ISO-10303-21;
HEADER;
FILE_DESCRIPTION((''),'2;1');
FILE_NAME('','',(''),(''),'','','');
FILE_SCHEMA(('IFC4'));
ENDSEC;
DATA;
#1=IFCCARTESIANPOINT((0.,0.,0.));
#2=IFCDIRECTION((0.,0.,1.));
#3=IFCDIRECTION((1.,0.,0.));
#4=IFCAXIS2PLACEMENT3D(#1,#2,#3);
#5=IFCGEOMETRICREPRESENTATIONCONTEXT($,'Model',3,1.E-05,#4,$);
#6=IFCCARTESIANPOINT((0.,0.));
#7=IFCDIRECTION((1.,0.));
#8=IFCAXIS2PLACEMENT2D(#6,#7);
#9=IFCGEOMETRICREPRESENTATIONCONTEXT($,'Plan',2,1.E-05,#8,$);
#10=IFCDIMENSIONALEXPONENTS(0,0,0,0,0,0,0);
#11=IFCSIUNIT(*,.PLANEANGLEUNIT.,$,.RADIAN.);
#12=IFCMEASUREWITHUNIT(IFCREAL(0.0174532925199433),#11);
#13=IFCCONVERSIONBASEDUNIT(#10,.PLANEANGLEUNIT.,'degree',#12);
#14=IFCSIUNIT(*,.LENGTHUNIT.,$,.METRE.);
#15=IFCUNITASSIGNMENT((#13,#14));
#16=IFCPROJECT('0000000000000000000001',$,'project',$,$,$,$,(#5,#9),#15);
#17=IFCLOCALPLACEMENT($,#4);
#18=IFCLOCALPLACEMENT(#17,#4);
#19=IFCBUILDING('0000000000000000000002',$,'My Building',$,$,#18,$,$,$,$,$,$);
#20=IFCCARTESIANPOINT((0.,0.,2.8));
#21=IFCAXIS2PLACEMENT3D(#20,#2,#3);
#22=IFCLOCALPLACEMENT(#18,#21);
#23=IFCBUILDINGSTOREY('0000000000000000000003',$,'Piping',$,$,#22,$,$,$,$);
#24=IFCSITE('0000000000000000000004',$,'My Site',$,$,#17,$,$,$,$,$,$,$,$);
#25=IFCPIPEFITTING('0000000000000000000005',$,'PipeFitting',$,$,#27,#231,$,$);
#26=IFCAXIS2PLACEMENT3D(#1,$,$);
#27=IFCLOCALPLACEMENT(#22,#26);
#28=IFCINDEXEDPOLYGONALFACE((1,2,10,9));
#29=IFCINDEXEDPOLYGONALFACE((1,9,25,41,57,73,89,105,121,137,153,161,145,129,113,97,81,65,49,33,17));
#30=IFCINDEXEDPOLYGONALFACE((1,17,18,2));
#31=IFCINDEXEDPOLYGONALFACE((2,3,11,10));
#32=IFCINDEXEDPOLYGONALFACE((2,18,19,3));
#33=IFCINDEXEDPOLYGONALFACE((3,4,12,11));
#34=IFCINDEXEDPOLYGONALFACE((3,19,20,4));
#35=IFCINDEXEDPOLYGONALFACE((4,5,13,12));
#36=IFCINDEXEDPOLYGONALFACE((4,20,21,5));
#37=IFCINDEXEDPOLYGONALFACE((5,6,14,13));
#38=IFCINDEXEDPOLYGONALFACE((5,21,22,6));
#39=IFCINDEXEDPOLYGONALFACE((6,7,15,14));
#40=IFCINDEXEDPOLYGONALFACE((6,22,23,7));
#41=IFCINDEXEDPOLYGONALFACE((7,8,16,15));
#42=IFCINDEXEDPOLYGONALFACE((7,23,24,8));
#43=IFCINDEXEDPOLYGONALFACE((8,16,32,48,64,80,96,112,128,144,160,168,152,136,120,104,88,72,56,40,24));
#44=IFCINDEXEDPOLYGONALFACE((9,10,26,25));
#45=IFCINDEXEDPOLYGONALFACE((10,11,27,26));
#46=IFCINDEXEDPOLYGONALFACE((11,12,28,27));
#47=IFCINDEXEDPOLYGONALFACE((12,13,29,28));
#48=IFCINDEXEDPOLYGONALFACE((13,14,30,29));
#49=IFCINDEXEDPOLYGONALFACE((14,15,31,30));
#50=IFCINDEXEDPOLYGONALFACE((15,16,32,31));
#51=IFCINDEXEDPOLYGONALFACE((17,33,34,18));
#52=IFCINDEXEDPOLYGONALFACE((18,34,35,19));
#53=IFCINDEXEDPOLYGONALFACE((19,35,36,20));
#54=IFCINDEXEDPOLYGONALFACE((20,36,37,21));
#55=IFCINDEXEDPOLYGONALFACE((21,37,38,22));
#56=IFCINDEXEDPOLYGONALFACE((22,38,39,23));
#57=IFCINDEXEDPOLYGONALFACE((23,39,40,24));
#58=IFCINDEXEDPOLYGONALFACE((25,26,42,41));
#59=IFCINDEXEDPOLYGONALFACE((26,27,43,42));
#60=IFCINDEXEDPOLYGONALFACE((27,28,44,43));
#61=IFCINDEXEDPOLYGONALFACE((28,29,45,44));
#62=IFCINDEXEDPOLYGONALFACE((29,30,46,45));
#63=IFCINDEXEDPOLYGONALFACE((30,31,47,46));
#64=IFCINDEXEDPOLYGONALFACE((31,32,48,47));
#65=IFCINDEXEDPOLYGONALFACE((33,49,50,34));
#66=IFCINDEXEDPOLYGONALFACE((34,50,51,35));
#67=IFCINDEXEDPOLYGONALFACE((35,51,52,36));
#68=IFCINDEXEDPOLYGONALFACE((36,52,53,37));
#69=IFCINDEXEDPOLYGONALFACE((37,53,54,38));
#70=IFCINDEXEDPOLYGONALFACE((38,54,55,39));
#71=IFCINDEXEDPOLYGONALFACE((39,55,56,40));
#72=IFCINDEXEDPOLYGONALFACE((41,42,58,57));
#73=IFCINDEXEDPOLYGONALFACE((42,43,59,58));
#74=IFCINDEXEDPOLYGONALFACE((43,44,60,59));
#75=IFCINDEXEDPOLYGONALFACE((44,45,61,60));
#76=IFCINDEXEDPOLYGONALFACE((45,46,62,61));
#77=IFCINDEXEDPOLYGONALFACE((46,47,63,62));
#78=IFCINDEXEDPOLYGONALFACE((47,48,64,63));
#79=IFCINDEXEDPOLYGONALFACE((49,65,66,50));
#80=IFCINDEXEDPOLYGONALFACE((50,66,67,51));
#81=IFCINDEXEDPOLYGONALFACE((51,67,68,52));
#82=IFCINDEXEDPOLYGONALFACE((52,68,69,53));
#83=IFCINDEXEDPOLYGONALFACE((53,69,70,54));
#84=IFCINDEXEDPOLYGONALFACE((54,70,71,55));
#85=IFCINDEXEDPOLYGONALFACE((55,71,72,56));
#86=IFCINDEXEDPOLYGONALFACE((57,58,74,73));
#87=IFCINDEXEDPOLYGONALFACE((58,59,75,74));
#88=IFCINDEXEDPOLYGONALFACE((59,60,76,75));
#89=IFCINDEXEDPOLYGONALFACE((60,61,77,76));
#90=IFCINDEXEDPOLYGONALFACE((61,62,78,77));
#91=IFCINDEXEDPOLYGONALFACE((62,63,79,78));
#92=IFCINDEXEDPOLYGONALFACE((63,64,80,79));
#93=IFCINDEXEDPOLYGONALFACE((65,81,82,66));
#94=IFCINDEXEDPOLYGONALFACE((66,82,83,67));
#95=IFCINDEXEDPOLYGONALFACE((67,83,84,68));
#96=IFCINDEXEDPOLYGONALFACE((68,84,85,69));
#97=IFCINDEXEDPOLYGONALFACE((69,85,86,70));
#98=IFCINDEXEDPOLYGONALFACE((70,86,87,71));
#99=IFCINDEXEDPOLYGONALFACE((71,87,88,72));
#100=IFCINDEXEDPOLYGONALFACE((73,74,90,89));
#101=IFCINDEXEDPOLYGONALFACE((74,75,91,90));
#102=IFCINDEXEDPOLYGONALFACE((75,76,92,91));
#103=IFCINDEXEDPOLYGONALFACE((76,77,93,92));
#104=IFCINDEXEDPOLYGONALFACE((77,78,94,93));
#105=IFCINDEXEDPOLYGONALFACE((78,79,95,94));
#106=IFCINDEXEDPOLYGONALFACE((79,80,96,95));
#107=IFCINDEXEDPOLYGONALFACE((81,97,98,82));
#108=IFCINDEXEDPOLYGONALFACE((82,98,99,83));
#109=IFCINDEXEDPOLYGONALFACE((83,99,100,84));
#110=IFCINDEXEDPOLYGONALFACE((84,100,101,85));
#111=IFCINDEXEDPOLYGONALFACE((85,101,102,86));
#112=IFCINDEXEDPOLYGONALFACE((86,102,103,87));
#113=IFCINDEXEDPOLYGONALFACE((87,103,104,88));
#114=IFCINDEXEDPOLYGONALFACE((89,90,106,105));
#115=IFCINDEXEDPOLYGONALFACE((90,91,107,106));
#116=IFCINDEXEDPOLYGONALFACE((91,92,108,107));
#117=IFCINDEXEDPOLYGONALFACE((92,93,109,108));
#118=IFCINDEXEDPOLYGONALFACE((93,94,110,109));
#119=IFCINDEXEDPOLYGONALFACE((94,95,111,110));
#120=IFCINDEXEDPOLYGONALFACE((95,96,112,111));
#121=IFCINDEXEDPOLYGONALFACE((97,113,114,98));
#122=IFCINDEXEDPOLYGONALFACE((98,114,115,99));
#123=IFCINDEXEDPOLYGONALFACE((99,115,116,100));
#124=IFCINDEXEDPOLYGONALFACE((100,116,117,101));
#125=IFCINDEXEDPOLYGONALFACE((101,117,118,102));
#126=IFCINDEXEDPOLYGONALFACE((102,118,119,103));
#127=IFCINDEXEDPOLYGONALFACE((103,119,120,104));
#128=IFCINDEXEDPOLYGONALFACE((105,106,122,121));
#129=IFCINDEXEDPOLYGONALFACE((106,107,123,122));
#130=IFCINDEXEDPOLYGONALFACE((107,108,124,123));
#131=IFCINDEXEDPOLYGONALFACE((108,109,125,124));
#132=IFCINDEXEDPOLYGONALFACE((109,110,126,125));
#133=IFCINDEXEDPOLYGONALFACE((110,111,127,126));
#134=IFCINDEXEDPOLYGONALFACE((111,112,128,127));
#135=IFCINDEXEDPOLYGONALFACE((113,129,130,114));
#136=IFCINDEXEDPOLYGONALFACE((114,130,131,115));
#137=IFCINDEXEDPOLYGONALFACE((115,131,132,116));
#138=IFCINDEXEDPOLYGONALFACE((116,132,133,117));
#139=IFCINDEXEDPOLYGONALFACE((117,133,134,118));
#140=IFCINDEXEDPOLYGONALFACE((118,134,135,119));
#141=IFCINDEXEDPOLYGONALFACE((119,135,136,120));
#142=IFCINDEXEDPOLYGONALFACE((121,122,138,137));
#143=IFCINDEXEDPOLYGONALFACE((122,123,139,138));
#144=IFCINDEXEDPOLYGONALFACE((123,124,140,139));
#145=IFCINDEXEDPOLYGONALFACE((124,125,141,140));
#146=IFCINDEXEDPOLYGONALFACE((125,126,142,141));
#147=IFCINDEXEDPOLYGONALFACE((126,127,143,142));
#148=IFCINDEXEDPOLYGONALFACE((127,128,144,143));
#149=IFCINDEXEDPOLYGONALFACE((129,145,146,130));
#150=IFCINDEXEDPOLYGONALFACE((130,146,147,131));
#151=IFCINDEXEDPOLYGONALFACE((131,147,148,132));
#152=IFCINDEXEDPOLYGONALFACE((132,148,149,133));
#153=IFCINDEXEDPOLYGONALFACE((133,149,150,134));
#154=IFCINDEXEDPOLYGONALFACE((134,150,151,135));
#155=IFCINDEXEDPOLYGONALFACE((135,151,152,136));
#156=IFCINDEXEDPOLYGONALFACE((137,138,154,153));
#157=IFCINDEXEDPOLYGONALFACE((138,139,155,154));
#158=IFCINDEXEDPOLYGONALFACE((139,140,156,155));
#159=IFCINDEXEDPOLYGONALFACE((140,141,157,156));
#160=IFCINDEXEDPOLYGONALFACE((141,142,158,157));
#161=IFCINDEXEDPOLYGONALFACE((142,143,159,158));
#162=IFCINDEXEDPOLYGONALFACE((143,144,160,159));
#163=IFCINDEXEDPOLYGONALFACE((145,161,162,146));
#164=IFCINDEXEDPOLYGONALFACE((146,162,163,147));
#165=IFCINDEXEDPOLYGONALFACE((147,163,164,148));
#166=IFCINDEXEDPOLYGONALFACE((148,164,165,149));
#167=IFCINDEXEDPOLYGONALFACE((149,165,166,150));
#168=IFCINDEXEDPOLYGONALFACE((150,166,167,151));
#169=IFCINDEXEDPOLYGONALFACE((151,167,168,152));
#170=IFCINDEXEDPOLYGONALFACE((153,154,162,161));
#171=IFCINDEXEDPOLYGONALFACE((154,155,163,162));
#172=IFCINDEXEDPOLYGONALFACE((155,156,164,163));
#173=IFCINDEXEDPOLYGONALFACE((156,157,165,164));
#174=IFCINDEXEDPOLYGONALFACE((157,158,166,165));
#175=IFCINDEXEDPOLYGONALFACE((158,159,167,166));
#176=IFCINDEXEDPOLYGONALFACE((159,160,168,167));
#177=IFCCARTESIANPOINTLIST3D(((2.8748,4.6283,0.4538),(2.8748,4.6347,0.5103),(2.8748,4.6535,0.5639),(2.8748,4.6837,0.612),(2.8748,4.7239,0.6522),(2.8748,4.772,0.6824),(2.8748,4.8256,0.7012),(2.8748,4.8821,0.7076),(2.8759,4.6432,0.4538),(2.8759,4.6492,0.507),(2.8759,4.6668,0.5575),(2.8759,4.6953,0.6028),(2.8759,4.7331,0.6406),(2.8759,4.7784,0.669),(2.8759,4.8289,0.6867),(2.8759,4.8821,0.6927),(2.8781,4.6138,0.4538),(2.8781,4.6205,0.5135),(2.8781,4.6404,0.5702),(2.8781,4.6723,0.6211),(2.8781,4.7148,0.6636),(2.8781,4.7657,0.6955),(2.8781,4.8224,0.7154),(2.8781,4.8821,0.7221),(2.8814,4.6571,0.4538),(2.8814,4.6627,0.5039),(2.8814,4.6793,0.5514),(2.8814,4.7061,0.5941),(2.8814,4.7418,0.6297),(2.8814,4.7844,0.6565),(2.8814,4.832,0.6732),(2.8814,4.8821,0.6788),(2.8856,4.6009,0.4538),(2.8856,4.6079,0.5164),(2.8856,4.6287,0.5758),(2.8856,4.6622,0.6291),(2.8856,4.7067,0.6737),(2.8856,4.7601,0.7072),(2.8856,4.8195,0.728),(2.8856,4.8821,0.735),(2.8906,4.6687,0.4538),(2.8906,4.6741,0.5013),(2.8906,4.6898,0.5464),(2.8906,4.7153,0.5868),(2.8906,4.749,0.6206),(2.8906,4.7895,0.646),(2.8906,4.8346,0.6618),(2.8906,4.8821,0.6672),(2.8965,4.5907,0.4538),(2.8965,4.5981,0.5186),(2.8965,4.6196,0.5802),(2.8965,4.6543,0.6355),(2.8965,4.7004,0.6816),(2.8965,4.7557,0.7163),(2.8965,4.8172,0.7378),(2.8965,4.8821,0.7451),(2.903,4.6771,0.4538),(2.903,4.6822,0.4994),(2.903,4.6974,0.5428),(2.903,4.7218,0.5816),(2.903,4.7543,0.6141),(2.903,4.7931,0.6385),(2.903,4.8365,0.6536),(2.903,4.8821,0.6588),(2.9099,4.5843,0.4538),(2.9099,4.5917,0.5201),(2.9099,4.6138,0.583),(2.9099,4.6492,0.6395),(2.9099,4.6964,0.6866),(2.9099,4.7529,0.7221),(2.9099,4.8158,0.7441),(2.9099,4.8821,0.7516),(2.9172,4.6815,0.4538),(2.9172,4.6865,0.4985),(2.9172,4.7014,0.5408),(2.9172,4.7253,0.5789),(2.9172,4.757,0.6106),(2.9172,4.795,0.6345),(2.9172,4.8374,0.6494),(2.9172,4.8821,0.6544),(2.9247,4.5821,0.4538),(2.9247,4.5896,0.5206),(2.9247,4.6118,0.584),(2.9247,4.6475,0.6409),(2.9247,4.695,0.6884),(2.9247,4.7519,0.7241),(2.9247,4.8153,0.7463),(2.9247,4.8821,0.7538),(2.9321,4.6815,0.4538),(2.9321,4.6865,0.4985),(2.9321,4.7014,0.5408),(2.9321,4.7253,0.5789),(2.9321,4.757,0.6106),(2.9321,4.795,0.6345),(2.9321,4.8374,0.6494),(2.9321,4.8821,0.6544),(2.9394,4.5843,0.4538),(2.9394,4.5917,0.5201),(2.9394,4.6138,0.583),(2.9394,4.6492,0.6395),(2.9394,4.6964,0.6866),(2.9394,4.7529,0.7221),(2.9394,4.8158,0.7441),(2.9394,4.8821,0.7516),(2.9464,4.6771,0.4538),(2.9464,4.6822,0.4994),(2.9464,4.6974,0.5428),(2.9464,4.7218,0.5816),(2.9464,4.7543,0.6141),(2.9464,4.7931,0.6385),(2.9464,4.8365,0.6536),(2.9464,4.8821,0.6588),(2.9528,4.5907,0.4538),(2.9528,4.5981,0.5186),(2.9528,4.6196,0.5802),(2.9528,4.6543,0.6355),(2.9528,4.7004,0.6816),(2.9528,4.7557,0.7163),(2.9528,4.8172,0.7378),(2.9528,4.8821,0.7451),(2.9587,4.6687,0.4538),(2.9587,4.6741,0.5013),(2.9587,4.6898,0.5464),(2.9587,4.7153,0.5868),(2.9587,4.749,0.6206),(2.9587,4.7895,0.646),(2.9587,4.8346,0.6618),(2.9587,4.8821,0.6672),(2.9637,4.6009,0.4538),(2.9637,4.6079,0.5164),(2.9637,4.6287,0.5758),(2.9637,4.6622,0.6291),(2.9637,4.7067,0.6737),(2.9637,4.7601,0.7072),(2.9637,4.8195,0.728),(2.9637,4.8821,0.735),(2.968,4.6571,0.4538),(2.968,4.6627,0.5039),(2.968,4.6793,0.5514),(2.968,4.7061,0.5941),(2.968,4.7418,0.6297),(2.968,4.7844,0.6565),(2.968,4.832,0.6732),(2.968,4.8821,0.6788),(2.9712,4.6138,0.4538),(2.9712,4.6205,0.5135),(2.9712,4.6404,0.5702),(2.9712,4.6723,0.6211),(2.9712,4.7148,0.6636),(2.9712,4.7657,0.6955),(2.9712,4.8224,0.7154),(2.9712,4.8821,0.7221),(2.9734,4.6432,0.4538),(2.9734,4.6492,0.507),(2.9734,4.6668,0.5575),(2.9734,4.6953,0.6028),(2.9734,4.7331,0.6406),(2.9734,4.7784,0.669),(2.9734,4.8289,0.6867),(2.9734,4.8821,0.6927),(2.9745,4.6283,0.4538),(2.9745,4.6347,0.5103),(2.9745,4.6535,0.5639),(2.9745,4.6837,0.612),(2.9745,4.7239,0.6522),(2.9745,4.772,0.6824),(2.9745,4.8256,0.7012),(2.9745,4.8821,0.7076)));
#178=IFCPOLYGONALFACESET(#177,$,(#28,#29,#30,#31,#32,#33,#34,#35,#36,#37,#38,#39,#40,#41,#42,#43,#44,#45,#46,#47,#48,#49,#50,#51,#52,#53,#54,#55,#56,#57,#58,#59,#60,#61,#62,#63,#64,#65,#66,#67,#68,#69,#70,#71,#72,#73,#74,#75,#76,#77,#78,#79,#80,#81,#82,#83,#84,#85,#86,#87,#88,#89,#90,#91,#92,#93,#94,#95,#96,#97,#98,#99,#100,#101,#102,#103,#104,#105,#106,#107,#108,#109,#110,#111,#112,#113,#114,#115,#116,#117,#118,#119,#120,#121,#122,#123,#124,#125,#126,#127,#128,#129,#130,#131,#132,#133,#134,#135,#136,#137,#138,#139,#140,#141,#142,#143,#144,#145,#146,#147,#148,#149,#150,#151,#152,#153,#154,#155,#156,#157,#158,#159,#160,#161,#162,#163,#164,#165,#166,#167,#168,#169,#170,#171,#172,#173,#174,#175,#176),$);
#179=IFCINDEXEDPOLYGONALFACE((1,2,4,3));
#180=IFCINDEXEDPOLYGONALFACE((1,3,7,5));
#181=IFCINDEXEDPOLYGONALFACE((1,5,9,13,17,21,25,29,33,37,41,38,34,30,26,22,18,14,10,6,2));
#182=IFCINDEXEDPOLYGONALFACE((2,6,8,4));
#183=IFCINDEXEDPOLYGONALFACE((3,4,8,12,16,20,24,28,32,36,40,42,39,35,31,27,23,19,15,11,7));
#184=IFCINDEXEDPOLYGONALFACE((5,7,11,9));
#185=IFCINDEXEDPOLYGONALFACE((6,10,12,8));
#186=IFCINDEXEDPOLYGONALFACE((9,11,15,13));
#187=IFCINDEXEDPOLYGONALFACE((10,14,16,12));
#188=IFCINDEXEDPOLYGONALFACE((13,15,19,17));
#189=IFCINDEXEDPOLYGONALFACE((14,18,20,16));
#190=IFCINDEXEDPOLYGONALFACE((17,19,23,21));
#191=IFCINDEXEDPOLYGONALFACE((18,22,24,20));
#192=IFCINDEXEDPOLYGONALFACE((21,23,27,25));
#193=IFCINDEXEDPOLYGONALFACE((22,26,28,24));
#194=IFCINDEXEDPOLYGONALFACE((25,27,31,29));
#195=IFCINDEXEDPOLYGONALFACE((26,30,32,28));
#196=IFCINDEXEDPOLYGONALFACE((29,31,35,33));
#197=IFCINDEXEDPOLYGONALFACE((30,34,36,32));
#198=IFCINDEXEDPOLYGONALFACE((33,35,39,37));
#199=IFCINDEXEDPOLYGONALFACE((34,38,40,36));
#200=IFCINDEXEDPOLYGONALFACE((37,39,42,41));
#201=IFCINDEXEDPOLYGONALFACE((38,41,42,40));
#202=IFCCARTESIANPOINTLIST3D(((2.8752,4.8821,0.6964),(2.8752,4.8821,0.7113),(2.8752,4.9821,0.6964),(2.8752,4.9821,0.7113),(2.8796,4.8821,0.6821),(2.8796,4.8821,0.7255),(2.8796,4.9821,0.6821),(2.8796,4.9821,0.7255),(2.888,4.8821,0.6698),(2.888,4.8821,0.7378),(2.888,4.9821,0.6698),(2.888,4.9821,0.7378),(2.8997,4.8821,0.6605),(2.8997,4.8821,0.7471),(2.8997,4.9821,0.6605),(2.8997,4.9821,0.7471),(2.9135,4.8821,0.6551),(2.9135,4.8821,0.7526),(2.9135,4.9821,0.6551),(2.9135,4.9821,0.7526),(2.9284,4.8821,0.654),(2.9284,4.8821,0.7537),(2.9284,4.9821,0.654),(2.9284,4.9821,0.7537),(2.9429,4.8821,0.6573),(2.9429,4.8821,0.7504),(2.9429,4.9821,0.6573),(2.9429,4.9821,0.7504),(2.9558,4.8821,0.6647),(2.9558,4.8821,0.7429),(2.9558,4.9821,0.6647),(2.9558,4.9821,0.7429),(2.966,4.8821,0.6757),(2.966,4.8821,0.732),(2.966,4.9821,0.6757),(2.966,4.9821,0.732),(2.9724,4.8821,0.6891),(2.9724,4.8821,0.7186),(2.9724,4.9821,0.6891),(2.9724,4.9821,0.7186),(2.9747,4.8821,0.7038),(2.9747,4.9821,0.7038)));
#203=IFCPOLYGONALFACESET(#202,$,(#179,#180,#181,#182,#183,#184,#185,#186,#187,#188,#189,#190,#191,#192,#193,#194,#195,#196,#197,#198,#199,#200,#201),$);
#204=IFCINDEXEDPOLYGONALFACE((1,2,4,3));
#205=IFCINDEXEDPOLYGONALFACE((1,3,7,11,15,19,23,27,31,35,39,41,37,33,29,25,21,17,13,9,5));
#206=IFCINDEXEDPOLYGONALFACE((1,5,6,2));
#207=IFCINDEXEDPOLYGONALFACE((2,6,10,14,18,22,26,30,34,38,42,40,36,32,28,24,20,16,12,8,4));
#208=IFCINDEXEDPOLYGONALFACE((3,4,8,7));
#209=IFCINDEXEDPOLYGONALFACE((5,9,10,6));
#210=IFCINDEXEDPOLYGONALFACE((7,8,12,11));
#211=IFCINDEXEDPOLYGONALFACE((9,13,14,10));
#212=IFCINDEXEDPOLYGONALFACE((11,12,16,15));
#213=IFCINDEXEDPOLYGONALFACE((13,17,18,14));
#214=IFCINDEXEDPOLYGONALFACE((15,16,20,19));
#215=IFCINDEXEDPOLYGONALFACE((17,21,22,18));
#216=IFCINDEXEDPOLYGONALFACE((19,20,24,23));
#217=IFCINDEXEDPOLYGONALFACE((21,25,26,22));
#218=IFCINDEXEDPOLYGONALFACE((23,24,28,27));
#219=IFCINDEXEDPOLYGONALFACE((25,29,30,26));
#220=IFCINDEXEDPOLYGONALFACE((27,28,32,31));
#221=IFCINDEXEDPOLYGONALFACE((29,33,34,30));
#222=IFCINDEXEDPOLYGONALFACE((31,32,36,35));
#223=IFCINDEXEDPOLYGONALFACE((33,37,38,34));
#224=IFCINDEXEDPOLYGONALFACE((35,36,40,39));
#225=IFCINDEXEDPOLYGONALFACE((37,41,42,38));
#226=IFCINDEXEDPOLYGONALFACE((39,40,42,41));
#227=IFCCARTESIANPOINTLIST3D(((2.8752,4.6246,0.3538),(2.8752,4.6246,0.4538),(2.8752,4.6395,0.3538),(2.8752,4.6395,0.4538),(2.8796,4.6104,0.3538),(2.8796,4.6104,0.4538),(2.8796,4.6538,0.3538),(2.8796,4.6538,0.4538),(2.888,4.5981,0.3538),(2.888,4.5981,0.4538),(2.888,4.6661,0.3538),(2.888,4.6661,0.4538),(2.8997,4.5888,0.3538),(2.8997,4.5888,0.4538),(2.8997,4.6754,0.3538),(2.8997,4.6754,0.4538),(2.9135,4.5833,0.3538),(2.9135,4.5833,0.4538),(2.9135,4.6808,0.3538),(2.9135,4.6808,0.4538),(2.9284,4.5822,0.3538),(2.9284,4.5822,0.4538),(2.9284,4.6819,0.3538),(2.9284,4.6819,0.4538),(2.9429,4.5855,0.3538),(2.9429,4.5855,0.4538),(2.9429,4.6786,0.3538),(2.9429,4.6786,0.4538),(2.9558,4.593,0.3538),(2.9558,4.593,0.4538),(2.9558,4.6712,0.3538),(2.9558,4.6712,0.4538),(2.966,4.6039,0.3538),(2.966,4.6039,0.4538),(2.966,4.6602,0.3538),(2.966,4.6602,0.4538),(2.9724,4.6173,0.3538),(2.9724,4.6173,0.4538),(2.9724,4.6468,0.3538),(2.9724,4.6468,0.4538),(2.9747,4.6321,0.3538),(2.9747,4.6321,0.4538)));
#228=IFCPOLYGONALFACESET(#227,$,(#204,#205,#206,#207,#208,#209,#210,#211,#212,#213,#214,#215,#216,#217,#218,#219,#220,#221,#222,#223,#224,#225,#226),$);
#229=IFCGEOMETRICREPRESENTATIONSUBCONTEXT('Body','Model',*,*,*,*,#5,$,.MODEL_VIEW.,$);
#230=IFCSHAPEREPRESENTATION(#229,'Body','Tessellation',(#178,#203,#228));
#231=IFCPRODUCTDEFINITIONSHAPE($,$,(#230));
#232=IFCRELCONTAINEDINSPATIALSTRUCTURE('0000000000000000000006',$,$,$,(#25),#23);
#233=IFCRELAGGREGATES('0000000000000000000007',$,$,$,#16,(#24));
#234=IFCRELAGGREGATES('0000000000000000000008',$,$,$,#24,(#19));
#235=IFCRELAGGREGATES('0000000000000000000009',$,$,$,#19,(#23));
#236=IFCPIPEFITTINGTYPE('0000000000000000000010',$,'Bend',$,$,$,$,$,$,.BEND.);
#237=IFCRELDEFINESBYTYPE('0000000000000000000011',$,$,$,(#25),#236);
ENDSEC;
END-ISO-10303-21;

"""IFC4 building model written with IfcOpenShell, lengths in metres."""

from ifc_helpers import new_model, entity, si_unit, converted_unit, frame, origin_with_axes, origin_2d_with_axis, place, context, subcontext, project, spatial, circle, extrude, source, transform, mapped, type_object, type_shapes, element, save


model = new_model("IFC4")

# Units and contexts
model_context = context("Model", 3, precision=1e-05, world=origin_with_axes())
plan_context = context("Plan", 2, precision=1e-05, world=origin_2d_with_axis())
body_context = subcontext(model_context, "Body", "Model", "MODEL_VIEW")
ifc_project = project(units=[converted_unit("PLANEANGLEUNIT", "degree", entity("IfcReal", 0.0174532925199433), si_unit("PLANEANGLEUNIT", "RADIAN"), dimensions=[0, 0, 0, 0, 0, 0, 0]), si_unit("LENGTHUNIT", "METRE")], contexts=[model_context, plan_context])

# Site, building, storey
site_placement = place(None, origin_with_axes())
site = spatial("IfcSite", under=ifc_project, at=site_placement, Name="My Site")
building_placement = place(site_placement, origin_with_axes())
building = spatial("IfcBuilding", under=site, at=building_placement, Name="My Building")
storey_placement = place(building_placement, frame((0.0, 0.0, 2.8), z_axis=(0.0, 0.0, 1.0), x_axis=(1.0, 0.0, 0.0)))
storey = spatial("IfcBuildingStorey", under=building, at=storey_placement, Name="Piping")

# Pipe fitting
pipe_fitting_type_1 = type_object("IfcPipeFittingType", Name="Bend", PredefinedType="BEND")
shared_shape = source(origin_with_axes(), body_context, "Body", "SolidModel", [
    entity("IfcSweptDiskSolid", entity("IfcIndexedPolyCurve", entity("IfcCartesianPointList3D", [[0.0, 0.0, 0.1], [0.0, -0.0732, 0.2768], [0.0, -0.25, 0.35]]), [entity("IfcArcIndex", [1, 2, 3])]), 0.05),
    extrude(circle(Radius=0.05), origin_with_axes(), (0.0, 0.0, 1.0), 0.1),
    extrude(circle(Radius=0.05), frame((0.0, -0.25, 0.35), z_axis=(0.0, -1.0, 0.0), x_axis=(1.0, 0.0, 0.0)), (0.0, 0.0, 1.0), 0.1),
])
type_shapes(pipe_fitting_type_1, [shared_shape])
for number, where, z_axis, x_axis, name in (
    (1, (2.9247, 4.9821, 0.7038), (0.0, -1.0, 0.0), (1.0, 0.0, 0.0), "PipeFitting"),
):
    element("IfcPipeFitting", number, at=place(storey_placement, frame(where, z_axis=z_axis, x_axis=x_axis)), inside=storey, type_object=pipe_fitting_type_1, Name=name, context=body_context, shape_type="MappedRepresentation", body=[
        mapped(shared_shape, transform((0.0, 0.0, 0.0), x_axis=(1.0, 0.0, 0.0), y_axis=(0.0, 1.0, 0.0), z_axis=(0.0, 0.0, 1.0), scale=1.0)),
    ])

save(model, "model.ifc")
